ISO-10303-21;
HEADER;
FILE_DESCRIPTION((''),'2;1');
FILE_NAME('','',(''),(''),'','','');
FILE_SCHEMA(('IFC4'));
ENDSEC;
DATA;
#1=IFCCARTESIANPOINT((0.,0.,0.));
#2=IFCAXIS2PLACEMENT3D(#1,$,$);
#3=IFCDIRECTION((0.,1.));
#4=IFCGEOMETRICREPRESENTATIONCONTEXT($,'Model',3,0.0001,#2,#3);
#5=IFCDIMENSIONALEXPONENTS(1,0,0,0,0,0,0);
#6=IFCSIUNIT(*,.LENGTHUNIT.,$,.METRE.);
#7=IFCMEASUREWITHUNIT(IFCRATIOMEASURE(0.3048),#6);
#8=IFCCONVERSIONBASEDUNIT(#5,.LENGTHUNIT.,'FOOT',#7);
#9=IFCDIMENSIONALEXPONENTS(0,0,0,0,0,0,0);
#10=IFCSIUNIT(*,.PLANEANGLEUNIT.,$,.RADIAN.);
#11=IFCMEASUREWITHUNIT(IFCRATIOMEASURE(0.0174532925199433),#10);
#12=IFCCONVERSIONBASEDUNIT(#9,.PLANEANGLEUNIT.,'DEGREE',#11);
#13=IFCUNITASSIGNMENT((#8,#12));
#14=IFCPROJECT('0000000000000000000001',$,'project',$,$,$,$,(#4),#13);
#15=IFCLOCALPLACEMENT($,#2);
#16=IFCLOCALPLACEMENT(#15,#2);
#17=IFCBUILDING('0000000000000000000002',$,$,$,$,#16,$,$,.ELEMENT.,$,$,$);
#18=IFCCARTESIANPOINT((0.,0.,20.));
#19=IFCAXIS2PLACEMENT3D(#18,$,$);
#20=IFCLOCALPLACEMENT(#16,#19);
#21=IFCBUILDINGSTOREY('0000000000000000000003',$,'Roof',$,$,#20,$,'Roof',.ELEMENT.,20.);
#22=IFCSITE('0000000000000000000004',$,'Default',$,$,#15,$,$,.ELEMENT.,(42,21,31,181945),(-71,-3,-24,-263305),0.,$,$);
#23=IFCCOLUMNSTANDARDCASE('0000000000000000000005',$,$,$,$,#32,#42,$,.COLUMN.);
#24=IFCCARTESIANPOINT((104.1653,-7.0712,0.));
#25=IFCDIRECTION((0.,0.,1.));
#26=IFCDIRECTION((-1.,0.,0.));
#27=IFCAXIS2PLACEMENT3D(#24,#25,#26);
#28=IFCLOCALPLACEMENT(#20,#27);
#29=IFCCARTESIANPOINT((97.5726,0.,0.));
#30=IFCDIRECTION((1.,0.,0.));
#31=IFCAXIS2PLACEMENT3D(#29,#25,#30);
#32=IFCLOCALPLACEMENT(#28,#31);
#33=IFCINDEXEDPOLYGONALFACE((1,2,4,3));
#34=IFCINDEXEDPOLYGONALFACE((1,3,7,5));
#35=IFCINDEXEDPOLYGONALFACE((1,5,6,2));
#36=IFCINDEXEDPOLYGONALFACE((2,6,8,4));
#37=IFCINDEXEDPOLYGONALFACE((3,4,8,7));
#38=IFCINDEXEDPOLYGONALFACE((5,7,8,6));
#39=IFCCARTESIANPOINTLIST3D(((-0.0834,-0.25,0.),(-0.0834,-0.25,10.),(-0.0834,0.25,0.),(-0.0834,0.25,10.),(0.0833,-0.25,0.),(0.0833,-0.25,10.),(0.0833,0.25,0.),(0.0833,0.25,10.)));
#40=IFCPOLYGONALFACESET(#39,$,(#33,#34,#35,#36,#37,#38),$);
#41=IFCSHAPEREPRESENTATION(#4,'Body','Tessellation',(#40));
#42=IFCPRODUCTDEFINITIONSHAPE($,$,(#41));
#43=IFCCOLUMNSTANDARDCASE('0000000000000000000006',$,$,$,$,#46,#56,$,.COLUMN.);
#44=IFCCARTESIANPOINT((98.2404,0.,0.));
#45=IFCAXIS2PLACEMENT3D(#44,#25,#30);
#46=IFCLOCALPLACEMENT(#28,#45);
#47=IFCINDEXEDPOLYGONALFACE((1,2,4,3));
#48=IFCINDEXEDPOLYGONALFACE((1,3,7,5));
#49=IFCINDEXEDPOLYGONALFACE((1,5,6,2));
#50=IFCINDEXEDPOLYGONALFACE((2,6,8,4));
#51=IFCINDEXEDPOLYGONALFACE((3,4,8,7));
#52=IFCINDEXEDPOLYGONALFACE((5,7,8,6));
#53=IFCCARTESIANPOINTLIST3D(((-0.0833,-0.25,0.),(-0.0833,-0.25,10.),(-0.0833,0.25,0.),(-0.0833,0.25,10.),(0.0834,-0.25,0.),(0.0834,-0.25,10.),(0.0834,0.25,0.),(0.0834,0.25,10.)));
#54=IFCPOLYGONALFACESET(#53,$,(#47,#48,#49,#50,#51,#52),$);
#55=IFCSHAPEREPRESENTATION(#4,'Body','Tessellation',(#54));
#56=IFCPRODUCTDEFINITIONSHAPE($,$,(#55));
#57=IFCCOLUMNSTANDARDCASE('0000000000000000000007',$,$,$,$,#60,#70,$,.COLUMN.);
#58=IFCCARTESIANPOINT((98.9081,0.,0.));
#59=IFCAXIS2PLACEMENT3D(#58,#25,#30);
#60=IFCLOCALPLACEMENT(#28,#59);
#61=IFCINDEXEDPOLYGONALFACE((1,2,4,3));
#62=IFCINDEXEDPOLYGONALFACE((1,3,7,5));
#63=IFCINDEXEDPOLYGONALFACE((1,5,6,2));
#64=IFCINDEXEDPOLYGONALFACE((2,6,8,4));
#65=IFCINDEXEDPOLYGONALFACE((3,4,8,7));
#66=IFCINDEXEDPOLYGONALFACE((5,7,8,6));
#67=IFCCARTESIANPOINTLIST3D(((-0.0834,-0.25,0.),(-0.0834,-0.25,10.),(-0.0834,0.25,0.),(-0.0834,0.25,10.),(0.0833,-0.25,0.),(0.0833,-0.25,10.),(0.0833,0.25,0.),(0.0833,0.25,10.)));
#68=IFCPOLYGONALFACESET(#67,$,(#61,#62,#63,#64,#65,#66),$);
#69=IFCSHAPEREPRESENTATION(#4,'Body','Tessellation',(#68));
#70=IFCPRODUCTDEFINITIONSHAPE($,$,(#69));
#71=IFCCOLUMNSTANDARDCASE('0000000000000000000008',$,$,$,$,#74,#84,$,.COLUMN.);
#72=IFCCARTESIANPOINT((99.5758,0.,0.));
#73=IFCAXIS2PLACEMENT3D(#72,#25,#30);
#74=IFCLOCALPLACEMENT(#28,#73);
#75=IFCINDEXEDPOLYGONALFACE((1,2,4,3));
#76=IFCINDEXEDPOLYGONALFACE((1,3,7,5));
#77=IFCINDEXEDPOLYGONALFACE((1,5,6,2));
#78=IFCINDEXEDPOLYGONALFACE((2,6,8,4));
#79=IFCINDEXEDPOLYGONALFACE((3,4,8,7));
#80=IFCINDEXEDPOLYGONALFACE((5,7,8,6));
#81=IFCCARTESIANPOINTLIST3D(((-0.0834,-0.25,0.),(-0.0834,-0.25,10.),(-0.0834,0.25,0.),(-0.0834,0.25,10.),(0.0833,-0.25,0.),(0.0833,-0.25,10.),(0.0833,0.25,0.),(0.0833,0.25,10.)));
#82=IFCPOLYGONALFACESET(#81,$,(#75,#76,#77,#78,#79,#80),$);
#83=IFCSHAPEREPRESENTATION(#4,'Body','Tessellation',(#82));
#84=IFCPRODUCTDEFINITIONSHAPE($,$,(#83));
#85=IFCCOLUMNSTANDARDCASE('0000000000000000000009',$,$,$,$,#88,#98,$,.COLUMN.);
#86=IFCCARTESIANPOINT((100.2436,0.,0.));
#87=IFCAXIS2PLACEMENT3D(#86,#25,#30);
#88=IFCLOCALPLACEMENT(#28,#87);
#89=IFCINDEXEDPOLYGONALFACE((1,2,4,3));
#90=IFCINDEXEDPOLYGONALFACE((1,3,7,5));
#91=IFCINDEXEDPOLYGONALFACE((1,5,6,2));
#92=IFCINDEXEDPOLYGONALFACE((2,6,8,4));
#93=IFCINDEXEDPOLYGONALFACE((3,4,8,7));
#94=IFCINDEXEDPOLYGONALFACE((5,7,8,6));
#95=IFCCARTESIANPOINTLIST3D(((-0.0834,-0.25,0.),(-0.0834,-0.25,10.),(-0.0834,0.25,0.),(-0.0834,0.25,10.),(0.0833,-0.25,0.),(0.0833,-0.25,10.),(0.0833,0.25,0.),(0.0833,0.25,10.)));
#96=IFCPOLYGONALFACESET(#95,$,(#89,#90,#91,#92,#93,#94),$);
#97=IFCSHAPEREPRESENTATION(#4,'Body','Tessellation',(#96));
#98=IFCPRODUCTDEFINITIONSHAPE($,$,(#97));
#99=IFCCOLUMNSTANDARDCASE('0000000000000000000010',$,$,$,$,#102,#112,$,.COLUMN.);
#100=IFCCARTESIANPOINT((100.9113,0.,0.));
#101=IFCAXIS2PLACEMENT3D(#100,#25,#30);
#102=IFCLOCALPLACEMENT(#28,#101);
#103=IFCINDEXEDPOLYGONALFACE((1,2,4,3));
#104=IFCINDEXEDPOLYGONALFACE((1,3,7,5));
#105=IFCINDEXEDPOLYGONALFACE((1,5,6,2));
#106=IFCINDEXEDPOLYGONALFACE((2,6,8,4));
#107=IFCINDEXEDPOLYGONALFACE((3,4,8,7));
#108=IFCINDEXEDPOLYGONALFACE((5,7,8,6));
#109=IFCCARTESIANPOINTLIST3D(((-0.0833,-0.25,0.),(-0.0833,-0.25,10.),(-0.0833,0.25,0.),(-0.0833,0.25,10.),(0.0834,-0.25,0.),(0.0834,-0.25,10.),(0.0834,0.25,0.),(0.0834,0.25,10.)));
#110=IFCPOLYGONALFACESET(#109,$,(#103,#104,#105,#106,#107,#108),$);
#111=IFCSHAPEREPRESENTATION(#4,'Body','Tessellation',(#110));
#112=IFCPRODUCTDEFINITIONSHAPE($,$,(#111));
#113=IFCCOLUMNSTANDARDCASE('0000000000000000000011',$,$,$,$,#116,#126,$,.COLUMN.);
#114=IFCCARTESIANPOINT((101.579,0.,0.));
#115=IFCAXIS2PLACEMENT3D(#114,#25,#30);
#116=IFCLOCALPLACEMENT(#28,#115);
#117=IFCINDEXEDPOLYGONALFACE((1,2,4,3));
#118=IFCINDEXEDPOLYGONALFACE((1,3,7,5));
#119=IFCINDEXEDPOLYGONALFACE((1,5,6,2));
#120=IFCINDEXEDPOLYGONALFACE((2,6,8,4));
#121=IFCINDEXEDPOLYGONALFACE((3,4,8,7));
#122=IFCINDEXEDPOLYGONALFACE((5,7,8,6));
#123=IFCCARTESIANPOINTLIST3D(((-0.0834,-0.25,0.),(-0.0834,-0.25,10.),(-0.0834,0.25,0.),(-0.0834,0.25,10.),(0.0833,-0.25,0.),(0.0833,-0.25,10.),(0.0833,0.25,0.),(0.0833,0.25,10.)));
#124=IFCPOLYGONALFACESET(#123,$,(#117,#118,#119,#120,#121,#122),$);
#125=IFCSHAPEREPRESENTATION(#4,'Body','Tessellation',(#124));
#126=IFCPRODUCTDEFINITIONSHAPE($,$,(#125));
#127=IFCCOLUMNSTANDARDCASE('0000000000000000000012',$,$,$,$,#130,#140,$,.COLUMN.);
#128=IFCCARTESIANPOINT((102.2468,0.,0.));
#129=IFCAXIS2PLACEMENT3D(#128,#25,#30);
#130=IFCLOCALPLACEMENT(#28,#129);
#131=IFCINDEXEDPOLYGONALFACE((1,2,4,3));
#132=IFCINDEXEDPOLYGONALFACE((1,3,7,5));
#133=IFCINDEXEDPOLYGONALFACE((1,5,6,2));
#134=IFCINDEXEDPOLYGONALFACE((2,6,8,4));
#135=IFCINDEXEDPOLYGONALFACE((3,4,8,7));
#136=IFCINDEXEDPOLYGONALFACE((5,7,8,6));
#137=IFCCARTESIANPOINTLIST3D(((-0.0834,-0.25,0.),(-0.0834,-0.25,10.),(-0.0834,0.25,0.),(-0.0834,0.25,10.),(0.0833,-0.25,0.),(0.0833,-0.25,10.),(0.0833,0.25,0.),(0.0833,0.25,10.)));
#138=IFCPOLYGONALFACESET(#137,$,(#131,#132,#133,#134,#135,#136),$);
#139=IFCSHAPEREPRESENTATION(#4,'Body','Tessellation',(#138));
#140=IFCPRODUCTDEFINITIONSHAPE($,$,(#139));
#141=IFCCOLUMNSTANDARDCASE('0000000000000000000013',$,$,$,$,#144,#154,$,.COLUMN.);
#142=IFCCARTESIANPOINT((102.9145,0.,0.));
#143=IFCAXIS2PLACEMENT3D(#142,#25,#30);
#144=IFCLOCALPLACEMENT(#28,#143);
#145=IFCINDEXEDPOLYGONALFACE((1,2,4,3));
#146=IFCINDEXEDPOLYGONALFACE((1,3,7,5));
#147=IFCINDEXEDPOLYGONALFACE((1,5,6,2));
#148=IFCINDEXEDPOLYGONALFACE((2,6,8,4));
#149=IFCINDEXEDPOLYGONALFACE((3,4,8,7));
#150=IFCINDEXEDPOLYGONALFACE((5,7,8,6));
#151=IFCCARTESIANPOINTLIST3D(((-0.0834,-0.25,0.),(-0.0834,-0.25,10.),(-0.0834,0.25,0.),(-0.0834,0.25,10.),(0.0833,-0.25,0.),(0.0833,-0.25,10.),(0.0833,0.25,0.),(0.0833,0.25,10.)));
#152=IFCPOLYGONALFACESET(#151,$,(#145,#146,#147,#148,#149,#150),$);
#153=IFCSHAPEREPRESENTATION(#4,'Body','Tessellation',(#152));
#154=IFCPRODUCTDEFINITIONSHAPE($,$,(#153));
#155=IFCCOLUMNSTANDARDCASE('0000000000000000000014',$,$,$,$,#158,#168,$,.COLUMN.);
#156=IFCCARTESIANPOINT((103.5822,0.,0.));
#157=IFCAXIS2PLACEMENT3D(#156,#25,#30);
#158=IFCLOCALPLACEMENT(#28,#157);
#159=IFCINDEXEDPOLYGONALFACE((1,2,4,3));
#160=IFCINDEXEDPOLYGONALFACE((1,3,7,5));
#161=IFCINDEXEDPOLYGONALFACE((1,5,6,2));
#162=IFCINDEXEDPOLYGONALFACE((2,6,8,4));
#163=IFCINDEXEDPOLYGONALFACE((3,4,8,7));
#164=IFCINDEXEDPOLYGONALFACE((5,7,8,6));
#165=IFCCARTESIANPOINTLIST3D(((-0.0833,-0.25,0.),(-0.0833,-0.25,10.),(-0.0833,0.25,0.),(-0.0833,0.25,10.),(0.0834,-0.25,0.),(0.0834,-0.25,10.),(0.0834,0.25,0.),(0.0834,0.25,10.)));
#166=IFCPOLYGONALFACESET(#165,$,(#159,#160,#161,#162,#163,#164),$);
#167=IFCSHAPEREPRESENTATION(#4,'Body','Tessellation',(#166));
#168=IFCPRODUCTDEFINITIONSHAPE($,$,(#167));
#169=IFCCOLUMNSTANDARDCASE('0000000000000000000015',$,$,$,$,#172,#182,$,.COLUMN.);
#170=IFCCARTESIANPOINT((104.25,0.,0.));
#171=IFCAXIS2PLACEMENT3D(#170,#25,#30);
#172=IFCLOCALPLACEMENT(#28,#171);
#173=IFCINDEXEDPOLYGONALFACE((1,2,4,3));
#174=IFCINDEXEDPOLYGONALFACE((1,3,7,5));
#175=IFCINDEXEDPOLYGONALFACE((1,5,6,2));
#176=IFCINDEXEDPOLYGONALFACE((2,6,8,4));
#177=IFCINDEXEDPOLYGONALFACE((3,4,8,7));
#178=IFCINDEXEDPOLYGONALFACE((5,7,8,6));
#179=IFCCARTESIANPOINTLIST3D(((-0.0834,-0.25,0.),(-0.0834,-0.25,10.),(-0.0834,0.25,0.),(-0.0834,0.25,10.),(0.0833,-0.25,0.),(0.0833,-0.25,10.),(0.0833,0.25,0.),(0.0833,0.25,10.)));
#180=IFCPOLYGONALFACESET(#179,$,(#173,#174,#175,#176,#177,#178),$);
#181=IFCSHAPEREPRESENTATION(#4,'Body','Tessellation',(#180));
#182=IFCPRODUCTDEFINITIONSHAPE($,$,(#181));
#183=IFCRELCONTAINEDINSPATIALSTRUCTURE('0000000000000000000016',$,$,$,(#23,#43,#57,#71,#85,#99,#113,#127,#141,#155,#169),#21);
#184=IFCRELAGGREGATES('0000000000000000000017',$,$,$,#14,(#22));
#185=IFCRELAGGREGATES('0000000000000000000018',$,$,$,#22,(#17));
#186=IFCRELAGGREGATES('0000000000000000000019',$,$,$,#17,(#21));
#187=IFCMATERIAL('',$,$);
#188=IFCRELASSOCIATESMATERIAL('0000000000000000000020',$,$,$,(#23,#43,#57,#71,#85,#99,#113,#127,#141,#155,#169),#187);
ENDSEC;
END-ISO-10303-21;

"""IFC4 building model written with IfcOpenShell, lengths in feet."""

from ifc_helpers import new_model, entity, si_unit, converted_unit, direction, frame, origin, place, context, project, spatial, rectangle, extrude, material, element, save


model = new_model("IFC4")

# Units and contexts
model_context = context("Model", 3, precision=0.0001, world=origin(), true_north=direction((0.0, 1.0)))
ifc_project = project(units=[converted_unit("LENGTHUNIT", "FOOT", entity("IfcRatioMeasure", 0.3048), si_unit("LENGTHUNIT", "METRE"), dimensions=[1, 0, 0, 0, 0, 0, 0]), converted_unit("PLANEANGLEUNIT", "DEGREE", entity("IfcRatioMeasure", 0.0174532925199433), si_unit("PLANEANGLEUNIT", "RADIAN"), dimensions=[0, 0, 0, 0, 0, 0, 0])], contexts=[model_context])

# Site, building, storey
site_placement = place(None, origin())
site = spatial("IfcSite", under=ifc_project, at=site_placement, Name="Default", CompositionType="ELEMENT", RefLatitude=(42, 21, 31, 181945), RefLongitude=(-71, -3, -24, -263305), RefElevation=0.0)
building_placement = place(site_placement, origin())
building = spatial("IfcBuilding", under=site, at=building_placement, CompositionType="ELEMENT")
storey_placement = place(building_placement, frame((0.0, 0.0, 20.0)))
storey = spatial("IfcBuildingStorey", under=building, at=storey_placement, Name="Roof", LongName="Roof", CompositionType="ELEMENT", Elevation=20.0)

# Columns
ifc_material = material(Name="")
placement = place(storey_placement, frame((104.1653, -7.0712, 0.0), z_axis=(0.0, 0.0, 1.0), x_axis=(-1.0, 0.0, 0.0)))
for number, where, z_axis, x_axis in (
    (1, (97.5726, 0.0, 0.0), (0.0, 0.0, 1.0), (1.0, 0.0, 0.0)),
    (2, (98.2404, 0.0, 0.0), (0.0, 0.0, 1.0), (1.0, 0.0, 0.0)),
    (3, (98.9081, 0.0, 0.0), (0.0, 0.0, 1.0), (1.0, 0.0, 0.0)),
    (4, (99.5758, 0.0, 0.0), (0.0, 0.0, 1.0), (1.0, 0.0, 0.0)),
    (5, (100.2436, 0.0, 0.0), (0.0, 0.0, 1.0), (1.0, 0.0, 0.0)),
    (6, (100.9113, 0.0, 0.0), (0.0, 0.0, 1.0), (1.0, 0.0, 0.0)),
    (7, (101.579, 0.0, 0.0), (0.0, 0.0, 1.0), (1.0, 0.0, 0.0)),
    (8, (102.2468, 0.0, 0.0), (0.0, 0.0, 1.0), (1.0, 0.0, 0.0)),
    (9, (102.9145, 0.0, 0.0), (0.0, 0.0, 1.0), (1.0, 0.0, 0.0)),
    (10, (103.5822, 0.0, 0.0), (0.0, 0.0, 1.0), (1.0, 0.0, 0.0)),
    (11, (104.25, 0.0, 0.0), (0.0, 0.0, 1.0), (1.0, 0.0, 0.0)),
):
    element("IfcColumnStandardCase", number, at=place(placement, frame(where, z_axis=z_axis, x_axis=x_axis)), inside=storey, material=ifc_material, PredefinedType="COLUMN", context=model_context, shape_type="SweptSolid", body=[
        extrude(rectangle(XDim=0.1667, YDim=0.5), origin(), (0.0, 0.0, 1.0), 10.0),
    ])

save(model, "model.ifc")
